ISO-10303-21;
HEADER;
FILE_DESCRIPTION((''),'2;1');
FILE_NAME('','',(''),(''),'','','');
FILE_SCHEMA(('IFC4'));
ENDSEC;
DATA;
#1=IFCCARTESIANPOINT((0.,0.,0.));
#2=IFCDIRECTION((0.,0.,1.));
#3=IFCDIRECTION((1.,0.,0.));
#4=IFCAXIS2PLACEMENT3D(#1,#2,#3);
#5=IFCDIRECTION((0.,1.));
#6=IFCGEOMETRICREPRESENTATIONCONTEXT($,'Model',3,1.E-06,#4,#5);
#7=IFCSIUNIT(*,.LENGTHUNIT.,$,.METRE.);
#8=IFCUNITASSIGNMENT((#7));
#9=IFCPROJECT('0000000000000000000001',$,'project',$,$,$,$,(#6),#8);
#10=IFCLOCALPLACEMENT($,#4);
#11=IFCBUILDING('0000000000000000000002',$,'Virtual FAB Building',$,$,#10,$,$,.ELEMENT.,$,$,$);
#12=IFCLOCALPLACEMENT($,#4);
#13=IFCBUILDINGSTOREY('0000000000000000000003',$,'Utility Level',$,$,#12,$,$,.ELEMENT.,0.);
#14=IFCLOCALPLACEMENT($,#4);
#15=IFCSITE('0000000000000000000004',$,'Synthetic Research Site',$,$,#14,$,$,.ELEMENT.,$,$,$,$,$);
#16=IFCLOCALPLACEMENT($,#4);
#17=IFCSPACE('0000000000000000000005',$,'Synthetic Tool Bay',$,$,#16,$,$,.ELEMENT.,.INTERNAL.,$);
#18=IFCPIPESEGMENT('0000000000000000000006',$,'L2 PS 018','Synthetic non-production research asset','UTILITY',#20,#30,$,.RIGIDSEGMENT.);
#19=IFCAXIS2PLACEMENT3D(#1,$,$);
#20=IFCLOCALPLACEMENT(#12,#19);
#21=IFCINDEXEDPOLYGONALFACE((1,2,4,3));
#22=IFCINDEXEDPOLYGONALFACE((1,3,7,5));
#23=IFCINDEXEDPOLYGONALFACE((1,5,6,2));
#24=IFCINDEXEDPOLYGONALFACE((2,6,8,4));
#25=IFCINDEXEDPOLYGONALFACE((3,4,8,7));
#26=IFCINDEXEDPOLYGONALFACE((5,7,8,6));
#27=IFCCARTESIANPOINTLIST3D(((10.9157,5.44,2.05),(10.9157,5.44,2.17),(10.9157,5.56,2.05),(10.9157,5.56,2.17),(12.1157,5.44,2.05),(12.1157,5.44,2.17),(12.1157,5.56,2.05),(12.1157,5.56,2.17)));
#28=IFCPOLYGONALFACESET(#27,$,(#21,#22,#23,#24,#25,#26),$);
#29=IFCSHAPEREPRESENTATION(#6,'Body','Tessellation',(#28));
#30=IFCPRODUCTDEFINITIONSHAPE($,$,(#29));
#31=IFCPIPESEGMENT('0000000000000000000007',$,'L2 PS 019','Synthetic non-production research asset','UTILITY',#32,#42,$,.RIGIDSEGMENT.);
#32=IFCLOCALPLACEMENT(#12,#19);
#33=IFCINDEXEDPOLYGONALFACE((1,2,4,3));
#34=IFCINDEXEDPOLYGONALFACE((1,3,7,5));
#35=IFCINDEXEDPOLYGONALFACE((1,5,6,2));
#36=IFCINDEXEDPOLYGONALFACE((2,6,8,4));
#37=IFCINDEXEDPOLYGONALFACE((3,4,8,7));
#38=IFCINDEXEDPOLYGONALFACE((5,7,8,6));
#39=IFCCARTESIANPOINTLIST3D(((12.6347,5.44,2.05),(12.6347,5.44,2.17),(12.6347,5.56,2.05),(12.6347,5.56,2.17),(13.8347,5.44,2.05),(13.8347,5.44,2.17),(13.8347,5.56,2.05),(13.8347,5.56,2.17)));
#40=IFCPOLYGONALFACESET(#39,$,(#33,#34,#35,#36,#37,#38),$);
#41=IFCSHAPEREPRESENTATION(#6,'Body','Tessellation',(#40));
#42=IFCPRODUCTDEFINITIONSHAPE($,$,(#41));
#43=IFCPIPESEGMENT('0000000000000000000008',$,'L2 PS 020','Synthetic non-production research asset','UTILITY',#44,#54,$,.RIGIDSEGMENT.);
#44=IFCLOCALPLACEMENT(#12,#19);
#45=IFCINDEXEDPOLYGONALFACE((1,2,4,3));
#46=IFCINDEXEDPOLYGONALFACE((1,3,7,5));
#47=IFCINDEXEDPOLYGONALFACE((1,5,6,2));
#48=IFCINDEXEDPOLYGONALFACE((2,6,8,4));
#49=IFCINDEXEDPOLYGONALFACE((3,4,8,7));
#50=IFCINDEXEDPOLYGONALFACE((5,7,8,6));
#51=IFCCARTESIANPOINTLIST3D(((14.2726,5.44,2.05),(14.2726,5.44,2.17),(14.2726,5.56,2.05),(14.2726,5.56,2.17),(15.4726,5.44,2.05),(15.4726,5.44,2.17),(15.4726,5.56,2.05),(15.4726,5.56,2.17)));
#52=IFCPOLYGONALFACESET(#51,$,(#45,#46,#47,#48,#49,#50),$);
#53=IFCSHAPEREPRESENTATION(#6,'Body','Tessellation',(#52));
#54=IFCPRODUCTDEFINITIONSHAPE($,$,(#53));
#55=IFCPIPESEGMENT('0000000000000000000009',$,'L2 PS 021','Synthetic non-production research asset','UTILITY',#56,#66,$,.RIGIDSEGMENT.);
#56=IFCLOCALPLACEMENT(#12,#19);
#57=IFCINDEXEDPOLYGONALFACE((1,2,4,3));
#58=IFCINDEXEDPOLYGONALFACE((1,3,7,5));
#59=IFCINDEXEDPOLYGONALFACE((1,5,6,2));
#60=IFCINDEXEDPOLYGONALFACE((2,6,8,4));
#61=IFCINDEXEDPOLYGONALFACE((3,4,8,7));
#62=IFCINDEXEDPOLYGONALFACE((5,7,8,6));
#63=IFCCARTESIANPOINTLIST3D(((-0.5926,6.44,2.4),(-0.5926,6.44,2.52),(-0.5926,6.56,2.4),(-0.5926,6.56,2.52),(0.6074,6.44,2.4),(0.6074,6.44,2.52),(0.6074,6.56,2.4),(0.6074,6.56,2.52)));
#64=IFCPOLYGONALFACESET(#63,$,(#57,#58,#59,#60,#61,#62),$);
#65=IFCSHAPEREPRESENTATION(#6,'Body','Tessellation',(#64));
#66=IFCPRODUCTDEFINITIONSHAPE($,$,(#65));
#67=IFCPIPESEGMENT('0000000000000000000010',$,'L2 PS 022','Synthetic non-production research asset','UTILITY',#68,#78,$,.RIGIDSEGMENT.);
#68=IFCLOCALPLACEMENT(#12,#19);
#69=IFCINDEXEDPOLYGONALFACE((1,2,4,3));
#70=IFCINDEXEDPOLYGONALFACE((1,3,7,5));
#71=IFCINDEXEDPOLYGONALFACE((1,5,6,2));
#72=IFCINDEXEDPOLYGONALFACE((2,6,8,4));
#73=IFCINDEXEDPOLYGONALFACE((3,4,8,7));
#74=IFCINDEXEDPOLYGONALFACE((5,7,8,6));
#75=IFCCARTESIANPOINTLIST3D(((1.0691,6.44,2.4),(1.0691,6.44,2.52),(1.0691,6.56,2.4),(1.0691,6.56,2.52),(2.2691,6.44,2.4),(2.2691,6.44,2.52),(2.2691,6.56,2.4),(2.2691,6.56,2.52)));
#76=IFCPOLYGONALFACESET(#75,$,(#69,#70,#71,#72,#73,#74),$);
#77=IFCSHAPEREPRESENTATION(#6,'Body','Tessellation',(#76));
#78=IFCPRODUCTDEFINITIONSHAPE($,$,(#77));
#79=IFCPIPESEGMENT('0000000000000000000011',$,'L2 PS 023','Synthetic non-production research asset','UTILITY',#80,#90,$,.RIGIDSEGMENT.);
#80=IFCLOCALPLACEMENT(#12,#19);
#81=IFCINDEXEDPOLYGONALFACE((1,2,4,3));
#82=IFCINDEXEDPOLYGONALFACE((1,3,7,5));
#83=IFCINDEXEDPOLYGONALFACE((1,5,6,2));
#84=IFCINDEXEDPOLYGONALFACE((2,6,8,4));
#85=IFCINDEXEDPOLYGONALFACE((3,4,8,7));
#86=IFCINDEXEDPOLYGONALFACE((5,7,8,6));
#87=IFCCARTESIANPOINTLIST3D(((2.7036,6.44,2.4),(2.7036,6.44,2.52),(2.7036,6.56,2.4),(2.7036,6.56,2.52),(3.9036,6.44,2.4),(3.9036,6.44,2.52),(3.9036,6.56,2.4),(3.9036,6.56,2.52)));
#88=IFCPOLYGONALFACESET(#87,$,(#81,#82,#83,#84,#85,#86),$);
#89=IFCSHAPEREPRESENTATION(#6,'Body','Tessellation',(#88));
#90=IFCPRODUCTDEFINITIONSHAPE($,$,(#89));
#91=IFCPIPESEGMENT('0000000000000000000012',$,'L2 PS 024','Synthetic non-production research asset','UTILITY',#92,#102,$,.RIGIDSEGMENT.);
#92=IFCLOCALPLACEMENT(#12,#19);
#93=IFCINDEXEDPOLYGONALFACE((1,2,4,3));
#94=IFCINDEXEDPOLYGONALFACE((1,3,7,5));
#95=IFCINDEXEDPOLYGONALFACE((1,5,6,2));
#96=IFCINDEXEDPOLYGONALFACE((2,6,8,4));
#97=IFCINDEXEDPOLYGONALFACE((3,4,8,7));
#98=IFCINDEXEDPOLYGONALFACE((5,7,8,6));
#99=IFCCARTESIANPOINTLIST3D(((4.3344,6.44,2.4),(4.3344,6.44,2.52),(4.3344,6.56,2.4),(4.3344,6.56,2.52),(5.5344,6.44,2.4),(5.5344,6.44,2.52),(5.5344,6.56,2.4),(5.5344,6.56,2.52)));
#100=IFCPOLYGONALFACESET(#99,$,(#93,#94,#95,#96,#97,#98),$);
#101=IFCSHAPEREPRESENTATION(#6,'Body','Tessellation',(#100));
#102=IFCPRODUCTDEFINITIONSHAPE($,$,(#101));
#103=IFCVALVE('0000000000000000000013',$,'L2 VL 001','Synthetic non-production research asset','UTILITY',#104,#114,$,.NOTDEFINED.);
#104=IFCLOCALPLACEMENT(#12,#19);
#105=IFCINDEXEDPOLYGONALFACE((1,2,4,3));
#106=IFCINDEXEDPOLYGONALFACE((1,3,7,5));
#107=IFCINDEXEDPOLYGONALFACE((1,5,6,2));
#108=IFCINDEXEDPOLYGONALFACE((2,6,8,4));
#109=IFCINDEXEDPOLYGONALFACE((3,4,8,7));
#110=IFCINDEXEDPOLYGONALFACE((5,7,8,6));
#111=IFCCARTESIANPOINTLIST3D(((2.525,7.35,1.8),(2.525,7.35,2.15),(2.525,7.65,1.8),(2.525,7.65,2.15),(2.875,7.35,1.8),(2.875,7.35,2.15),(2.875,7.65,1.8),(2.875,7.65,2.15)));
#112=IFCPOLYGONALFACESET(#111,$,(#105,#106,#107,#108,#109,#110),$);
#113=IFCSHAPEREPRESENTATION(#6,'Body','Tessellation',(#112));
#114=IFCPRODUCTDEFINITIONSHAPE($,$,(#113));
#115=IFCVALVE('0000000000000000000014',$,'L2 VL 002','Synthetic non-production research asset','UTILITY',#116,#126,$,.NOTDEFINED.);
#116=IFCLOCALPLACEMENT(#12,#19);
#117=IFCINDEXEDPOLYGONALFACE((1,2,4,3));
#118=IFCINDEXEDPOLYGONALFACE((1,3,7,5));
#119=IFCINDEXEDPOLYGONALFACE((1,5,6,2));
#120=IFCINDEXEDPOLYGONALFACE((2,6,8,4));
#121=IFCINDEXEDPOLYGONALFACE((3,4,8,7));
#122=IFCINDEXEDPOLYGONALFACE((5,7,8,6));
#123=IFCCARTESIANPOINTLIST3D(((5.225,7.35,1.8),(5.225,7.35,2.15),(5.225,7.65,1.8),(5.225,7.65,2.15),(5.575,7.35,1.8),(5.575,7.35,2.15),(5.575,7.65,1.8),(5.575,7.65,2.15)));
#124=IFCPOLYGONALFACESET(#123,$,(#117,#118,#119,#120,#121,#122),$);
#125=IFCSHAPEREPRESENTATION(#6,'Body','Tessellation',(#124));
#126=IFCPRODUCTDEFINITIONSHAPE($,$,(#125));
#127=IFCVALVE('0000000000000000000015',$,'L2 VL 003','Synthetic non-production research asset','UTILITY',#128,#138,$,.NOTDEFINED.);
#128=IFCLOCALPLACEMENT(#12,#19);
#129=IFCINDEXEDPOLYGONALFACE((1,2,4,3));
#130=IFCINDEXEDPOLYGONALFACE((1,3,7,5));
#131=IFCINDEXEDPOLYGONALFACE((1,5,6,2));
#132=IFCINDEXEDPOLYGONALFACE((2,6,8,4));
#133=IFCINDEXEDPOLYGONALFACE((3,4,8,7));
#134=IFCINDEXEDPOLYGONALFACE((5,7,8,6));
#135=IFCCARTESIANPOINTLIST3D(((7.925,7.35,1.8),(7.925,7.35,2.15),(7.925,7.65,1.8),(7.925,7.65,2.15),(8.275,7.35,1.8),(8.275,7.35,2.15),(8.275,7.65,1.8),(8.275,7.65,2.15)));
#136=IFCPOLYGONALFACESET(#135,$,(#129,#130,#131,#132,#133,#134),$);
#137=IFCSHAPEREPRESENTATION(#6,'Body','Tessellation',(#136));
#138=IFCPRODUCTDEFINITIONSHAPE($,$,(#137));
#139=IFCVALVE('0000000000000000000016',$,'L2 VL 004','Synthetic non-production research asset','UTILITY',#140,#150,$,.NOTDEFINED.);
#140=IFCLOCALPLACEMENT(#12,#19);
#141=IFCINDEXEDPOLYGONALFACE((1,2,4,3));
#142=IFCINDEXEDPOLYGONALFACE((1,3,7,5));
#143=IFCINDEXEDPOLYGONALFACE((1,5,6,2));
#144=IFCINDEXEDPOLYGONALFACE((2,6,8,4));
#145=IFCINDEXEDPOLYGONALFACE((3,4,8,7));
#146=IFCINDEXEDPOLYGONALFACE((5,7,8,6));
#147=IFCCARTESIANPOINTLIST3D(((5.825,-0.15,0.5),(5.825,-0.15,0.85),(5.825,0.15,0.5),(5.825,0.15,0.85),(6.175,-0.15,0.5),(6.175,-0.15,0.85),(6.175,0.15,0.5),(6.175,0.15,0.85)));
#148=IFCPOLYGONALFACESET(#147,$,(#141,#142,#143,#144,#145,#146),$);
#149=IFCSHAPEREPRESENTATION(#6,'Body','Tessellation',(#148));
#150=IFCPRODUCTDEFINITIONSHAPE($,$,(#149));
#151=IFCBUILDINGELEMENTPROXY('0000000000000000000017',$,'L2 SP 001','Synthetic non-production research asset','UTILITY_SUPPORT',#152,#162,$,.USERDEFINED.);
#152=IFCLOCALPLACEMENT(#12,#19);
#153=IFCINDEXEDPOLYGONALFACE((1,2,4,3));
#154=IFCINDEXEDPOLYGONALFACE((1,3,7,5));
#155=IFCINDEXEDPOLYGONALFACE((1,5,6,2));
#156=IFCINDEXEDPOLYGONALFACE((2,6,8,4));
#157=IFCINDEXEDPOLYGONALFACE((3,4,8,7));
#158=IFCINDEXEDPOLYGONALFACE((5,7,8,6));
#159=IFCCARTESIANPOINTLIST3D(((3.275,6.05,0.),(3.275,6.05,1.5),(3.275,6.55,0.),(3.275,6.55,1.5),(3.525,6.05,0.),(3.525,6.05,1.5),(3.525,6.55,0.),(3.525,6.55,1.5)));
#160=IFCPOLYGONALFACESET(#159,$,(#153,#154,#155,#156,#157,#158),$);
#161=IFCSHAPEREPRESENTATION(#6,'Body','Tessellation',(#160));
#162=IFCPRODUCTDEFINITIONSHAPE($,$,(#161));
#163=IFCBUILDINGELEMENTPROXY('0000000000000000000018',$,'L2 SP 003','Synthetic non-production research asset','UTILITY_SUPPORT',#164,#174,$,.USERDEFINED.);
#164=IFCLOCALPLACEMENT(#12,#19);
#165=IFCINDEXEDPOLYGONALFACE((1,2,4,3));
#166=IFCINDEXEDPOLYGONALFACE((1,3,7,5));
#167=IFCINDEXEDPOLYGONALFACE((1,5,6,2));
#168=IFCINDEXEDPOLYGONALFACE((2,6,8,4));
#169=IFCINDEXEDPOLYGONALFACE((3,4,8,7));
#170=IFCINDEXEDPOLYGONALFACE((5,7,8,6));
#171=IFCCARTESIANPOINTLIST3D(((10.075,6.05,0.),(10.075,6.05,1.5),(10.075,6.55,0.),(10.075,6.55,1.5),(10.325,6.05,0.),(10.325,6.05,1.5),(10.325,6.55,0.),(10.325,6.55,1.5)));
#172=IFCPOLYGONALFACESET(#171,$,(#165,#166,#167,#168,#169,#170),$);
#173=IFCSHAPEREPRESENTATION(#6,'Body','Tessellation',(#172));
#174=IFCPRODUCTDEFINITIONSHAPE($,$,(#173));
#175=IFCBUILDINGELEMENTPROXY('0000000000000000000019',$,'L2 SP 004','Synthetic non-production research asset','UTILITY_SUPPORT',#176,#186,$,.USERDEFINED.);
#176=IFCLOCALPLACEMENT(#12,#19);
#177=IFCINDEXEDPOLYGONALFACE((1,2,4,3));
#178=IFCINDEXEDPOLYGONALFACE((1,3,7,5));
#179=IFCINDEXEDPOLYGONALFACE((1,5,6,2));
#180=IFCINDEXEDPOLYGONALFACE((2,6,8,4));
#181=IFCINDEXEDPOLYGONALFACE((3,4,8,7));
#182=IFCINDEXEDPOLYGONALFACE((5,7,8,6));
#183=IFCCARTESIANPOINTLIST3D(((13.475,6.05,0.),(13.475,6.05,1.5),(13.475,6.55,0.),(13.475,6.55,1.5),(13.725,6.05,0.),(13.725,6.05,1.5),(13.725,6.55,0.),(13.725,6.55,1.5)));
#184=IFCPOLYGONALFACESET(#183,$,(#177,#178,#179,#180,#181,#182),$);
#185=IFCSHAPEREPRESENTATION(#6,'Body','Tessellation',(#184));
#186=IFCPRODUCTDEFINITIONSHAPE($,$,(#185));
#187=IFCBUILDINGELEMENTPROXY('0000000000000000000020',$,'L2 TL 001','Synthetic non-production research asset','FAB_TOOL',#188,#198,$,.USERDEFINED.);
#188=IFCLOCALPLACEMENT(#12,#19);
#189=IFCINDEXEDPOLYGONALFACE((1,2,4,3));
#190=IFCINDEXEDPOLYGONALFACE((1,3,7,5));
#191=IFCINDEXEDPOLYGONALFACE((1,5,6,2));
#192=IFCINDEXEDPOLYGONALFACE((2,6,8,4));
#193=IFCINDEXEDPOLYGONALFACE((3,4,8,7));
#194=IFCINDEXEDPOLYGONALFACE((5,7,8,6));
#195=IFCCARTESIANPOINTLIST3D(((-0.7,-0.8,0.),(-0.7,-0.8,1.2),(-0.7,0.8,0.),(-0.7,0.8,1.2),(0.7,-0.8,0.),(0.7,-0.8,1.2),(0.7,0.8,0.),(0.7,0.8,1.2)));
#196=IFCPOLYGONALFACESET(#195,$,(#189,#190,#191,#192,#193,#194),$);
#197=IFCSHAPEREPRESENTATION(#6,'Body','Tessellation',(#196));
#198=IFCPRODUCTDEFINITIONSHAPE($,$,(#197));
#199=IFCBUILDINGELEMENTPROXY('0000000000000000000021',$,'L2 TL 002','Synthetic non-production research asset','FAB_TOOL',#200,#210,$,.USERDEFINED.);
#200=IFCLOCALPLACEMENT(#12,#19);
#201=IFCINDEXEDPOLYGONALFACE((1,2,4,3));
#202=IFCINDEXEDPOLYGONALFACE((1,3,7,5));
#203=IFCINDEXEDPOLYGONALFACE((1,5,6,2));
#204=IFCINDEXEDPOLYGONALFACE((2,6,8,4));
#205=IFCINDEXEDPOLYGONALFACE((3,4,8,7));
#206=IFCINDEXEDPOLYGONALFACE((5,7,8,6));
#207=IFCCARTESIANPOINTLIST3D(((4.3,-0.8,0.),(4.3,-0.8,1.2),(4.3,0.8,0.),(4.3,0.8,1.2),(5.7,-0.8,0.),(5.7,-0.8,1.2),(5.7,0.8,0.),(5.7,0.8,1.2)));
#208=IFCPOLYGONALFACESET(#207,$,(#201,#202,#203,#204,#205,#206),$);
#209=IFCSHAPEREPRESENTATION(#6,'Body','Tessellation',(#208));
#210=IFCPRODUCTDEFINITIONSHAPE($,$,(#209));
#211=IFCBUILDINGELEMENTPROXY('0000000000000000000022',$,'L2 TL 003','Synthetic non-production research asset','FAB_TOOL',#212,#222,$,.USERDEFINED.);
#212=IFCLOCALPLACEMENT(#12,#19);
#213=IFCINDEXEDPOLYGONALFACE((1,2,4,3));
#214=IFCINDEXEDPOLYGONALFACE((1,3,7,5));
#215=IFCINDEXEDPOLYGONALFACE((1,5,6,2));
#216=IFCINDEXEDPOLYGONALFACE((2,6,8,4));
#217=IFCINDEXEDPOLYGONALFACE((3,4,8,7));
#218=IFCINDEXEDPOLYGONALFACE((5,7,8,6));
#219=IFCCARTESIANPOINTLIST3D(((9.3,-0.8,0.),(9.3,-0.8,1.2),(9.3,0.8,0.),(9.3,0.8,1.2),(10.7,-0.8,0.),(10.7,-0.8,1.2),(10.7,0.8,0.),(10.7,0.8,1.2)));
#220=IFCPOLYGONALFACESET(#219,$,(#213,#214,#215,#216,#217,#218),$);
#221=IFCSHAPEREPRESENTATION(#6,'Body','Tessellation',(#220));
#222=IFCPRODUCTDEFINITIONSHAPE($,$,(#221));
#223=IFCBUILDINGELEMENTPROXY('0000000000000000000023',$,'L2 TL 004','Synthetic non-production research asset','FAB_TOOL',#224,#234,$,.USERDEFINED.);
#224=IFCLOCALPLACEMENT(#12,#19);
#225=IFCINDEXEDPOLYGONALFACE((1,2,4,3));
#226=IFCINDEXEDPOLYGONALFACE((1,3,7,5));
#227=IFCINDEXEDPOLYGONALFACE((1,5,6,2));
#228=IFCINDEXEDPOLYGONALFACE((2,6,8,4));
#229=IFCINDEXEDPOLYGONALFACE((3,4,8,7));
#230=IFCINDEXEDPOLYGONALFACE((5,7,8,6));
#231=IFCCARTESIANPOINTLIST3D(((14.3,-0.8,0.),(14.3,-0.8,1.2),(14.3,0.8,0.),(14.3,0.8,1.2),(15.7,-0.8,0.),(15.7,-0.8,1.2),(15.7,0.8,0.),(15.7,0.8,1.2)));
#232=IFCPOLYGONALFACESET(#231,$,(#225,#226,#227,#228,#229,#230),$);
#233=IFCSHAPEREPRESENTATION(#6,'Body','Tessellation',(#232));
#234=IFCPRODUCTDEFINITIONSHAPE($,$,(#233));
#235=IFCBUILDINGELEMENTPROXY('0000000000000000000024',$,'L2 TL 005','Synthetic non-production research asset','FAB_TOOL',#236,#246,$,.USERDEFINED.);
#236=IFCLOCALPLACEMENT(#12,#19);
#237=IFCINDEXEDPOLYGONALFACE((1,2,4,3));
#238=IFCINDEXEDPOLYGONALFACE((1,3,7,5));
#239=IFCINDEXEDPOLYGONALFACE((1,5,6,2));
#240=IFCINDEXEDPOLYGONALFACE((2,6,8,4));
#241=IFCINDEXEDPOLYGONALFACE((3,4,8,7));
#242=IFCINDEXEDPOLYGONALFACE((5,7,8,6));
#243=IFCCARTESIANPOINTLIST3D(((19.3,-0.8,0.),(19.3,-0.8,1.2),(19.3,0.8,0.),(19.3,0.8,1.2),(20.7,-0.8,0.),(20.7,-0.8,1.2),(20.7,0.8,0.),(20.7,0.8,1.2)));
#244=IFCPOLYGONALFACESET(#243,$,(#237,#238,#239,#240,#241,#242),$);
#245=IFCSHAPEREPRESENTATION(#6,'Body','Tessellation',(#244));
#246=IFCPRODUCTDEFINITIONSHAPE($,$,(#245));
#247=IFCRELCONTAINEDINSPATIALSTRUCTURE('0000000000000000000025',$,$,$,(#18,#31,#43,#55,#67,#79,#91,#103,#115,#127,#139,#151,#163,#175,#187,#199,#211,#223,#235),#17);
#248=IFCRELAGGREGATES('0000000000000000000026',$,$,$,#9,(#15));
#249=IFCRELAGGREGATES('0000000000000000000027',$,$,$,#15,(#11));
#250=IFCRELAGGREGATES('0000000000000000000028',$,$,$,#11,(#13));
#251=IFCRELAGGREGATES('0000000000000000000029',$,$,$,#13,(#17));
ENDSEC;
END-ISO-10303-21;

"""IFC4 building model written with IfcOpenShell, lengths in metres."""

from ifc_helpers import new_model, si_unit, direction, frame, origin_with_axes, origin_2d_with_axis, place, context, project, spatial, rectangle, extrude, element, save


model = new_model("IFC4")

# Units and contexts
model_context = context("Model", 3, precision=1e-06, world=origin_with_axes(), true_north=direction((0.0, 1.0)))
ifc_project = project(units=[si_unit("LENGTHUNIT", "METRE")], contexts=[model_context])

# Site, building, storey, space
site_placement = place(None, origin_with_axes())
site = spatial("IfcSite", under=ifc_project, at=site_placement, Name="Synthetic Research Site", CompositionType="ELEMENT")
building_placement = place(None, origin_with_axes())
building = spatial("IfcBuilding", under=site, at=building_placement, Name="Virtual FAB Building", CompositionType="ELEMENT")
storey_placement = place(None, origin_with_axes())
storey = spatial("IfcBuildingStorey", under=building, at=storey_placement, Name="Utility Level", CompositionType="ELEMENT", Elevation=0.0)
space_placement = place(None, origin_with_axes())
space = spatial("IfcSpace", under=storey, at=space_placement, Name="Synthetic Tool Bay", CompositionType="ELEMENT", PredefinedType="INTERNAL")

# Pipe segments
for number, where, z_axis, x_axis, name in (
    (1, (11.5157, 5.5, 2.05), (0.0, 0.0, 1.0), (1.0, 0.0, 0.0), "L2 PS 018"),
    (2, (13.2347, 5.5, 2.05), (0.0, 0.0, 1.0), (1.0, 0.0, 0.0), "L2 PS 019"),
    (3, (14.8726, 5.5, 2.05), (0.0, 0.0, 1.0), (1.0, 0.0, 0.0), "L2 PS 020"),
    (4, (0.0074, 6.5, 2.4), (0.0, 0.0, 1.0), (1.0, 0.0, 0.0), "L2 PS 021"),
    (5, (1.6691, 6.5, 2.4), (0.0, 0.0, 1.0), (1.0, 0.0, 0.0), "L2 PS 022"),
    (6, (3.3036, 6.5, 2.4), (0.0, 0.0, 1.0), (1.0, 0.0, 0.0), "L2 PS 023"),
    (7, (4.9344, 6.5, 2.4), (0.0, 0.0, 1.0), (1.0, 0.0, 0.0), "L2 PS 024"),
):
    element("IfcPipeSegment", number, at=place(None, frame(where, z_axis=z_axis, x_axis=x_axis)), inside=space, Name=name, Description="Synthetic non-production research asset", ObjectType="UTILITY", PredefinedType="RIGIDSEGMENT", context=model_context, shape_type="SweptSolid", body=[
        extrude(rectangle(XDim=1.2, YDim=0.12, at=origin_2d_with_axis()), origin_with_axes(), (0.0, 0.0, 1.0), 0.12),
    ])

# Valves
for number, where, z_axis, x_axis, name in (
    (8, (2.7, 7.5, 1.8), (0.0, 0.0, 1.0), (1.0, 0.0, 0.0), "L2 VL 001"),
    (9, (5.4, 7.5, 1.8), (0.0, 0.0, 1.0), (1.0, 0.0, 0.0), "L2 VL 002"),
    (10, (8.1, 7.5, 1.8), (0.0, 0.0, 1.0), (1.0, 0.0, 0.0), "L2 VL 003"),
    (11, (6.0, 0.0, 0.5), (0.0, 0.0, 1.0), (1.0, 0.0, 0.0), "L2 VL 004"),
):
    element("IfcValve", number, at=place(None, frame(where, z_axis=z_axis, x_axis=x_axis)), inside=space, Name=name, Description="Synthetic non-production research asset", ObjectType="UTILITY", PredefinedType="NOTDEFINED", context=model_context, shape_type="SweptSolid", body=[
        extrude(rectangle(XDim=0.35, YDim=0.3, at=origin_2d_with_axis()), origin_with_axes(), (0.0, 0.0, 1.0), 0.35),
    ])

# Building element proxies
for number, where, z_axis, x_axis, name in (
    (12, (3.4, 6.3, 0.0), (0.0, 0.0, 1.0), (1.0, 0.0, 0.0), "L2 SP 001"),
    (13, (10.2, 6.3, 0.0), (0.0, 0.0, 1.0), (1.0, 0.0, 0.0), "L2 SP 003"),
    (14, (13.6, 6.3, 0.0), (0.0, 0.0, 1.0), (1.0, 0.0, 0.0), "L2 SP 004"),
):
    element("IfcBuildingElementProxy", number, at=place(None, frame(where, z_axis=z_axis, x_axis=x_axis)), inside=space, Name=name, Description="Synthetic non-production research asset", ObjectType="UTILITY_SUPPORT", PredefinedType="USERDEFINED", context=model_context, shape_type="SweptSolid", body=[
        extrude(rectangle(XDim=0.25, YDim=0.5, at=origin_2d_with_axis()), origin_with_axes(), (0.0, 0.0, 1.0), 1.5),
    ])
for number, where, z_axis, x_axis, name in (
    (15, (0.0, 0.0, 0.0), (0.0, 0.0, 1.0), (1.0, 0.0, 0.0), "L2 TL 001"),
    (16, (5.0, 0.0, 0.0), (0.0, 0.0, 1.0), (1.0, 0.0, 0.0), "L2 TL 002"),
    (17, (10.0, 0.0, 0.0), (0.0, 0.0, 1.0), (1.0, 0.0, 0.0), "L2 TL 003"),
    (18, (15.0, 0.0, 0.0), (0.0, 0.0, 1.0), (1.0, 0.0, 0.0), "L2 TL 004"),
    (19, (20.0, 0.0, 0.0), (0.0, 0.0, 1.0), (1.0, 0.0, 0.0), "L2 TL 005"),
):
    element("IfcBuildingElementProxy", number, at=place(None, frame(where, z_axis=z_axis, x_axis=x_axis)), inside=space, Name=name, Description="Synthetic non-production research asset", ObjectType="FAB_TOOL", PredefinedType="USERDEFINED", context=model_context, shape_type="SweptSolid", body=[
        extrude(rectangle(XDim=1.4, YDim=1.6, at=origin_2d_with_axis()), origin_with_axes(), (0.0, 0.0, 1.0), 1.2),
    ])

save(model, "model.ifc")
